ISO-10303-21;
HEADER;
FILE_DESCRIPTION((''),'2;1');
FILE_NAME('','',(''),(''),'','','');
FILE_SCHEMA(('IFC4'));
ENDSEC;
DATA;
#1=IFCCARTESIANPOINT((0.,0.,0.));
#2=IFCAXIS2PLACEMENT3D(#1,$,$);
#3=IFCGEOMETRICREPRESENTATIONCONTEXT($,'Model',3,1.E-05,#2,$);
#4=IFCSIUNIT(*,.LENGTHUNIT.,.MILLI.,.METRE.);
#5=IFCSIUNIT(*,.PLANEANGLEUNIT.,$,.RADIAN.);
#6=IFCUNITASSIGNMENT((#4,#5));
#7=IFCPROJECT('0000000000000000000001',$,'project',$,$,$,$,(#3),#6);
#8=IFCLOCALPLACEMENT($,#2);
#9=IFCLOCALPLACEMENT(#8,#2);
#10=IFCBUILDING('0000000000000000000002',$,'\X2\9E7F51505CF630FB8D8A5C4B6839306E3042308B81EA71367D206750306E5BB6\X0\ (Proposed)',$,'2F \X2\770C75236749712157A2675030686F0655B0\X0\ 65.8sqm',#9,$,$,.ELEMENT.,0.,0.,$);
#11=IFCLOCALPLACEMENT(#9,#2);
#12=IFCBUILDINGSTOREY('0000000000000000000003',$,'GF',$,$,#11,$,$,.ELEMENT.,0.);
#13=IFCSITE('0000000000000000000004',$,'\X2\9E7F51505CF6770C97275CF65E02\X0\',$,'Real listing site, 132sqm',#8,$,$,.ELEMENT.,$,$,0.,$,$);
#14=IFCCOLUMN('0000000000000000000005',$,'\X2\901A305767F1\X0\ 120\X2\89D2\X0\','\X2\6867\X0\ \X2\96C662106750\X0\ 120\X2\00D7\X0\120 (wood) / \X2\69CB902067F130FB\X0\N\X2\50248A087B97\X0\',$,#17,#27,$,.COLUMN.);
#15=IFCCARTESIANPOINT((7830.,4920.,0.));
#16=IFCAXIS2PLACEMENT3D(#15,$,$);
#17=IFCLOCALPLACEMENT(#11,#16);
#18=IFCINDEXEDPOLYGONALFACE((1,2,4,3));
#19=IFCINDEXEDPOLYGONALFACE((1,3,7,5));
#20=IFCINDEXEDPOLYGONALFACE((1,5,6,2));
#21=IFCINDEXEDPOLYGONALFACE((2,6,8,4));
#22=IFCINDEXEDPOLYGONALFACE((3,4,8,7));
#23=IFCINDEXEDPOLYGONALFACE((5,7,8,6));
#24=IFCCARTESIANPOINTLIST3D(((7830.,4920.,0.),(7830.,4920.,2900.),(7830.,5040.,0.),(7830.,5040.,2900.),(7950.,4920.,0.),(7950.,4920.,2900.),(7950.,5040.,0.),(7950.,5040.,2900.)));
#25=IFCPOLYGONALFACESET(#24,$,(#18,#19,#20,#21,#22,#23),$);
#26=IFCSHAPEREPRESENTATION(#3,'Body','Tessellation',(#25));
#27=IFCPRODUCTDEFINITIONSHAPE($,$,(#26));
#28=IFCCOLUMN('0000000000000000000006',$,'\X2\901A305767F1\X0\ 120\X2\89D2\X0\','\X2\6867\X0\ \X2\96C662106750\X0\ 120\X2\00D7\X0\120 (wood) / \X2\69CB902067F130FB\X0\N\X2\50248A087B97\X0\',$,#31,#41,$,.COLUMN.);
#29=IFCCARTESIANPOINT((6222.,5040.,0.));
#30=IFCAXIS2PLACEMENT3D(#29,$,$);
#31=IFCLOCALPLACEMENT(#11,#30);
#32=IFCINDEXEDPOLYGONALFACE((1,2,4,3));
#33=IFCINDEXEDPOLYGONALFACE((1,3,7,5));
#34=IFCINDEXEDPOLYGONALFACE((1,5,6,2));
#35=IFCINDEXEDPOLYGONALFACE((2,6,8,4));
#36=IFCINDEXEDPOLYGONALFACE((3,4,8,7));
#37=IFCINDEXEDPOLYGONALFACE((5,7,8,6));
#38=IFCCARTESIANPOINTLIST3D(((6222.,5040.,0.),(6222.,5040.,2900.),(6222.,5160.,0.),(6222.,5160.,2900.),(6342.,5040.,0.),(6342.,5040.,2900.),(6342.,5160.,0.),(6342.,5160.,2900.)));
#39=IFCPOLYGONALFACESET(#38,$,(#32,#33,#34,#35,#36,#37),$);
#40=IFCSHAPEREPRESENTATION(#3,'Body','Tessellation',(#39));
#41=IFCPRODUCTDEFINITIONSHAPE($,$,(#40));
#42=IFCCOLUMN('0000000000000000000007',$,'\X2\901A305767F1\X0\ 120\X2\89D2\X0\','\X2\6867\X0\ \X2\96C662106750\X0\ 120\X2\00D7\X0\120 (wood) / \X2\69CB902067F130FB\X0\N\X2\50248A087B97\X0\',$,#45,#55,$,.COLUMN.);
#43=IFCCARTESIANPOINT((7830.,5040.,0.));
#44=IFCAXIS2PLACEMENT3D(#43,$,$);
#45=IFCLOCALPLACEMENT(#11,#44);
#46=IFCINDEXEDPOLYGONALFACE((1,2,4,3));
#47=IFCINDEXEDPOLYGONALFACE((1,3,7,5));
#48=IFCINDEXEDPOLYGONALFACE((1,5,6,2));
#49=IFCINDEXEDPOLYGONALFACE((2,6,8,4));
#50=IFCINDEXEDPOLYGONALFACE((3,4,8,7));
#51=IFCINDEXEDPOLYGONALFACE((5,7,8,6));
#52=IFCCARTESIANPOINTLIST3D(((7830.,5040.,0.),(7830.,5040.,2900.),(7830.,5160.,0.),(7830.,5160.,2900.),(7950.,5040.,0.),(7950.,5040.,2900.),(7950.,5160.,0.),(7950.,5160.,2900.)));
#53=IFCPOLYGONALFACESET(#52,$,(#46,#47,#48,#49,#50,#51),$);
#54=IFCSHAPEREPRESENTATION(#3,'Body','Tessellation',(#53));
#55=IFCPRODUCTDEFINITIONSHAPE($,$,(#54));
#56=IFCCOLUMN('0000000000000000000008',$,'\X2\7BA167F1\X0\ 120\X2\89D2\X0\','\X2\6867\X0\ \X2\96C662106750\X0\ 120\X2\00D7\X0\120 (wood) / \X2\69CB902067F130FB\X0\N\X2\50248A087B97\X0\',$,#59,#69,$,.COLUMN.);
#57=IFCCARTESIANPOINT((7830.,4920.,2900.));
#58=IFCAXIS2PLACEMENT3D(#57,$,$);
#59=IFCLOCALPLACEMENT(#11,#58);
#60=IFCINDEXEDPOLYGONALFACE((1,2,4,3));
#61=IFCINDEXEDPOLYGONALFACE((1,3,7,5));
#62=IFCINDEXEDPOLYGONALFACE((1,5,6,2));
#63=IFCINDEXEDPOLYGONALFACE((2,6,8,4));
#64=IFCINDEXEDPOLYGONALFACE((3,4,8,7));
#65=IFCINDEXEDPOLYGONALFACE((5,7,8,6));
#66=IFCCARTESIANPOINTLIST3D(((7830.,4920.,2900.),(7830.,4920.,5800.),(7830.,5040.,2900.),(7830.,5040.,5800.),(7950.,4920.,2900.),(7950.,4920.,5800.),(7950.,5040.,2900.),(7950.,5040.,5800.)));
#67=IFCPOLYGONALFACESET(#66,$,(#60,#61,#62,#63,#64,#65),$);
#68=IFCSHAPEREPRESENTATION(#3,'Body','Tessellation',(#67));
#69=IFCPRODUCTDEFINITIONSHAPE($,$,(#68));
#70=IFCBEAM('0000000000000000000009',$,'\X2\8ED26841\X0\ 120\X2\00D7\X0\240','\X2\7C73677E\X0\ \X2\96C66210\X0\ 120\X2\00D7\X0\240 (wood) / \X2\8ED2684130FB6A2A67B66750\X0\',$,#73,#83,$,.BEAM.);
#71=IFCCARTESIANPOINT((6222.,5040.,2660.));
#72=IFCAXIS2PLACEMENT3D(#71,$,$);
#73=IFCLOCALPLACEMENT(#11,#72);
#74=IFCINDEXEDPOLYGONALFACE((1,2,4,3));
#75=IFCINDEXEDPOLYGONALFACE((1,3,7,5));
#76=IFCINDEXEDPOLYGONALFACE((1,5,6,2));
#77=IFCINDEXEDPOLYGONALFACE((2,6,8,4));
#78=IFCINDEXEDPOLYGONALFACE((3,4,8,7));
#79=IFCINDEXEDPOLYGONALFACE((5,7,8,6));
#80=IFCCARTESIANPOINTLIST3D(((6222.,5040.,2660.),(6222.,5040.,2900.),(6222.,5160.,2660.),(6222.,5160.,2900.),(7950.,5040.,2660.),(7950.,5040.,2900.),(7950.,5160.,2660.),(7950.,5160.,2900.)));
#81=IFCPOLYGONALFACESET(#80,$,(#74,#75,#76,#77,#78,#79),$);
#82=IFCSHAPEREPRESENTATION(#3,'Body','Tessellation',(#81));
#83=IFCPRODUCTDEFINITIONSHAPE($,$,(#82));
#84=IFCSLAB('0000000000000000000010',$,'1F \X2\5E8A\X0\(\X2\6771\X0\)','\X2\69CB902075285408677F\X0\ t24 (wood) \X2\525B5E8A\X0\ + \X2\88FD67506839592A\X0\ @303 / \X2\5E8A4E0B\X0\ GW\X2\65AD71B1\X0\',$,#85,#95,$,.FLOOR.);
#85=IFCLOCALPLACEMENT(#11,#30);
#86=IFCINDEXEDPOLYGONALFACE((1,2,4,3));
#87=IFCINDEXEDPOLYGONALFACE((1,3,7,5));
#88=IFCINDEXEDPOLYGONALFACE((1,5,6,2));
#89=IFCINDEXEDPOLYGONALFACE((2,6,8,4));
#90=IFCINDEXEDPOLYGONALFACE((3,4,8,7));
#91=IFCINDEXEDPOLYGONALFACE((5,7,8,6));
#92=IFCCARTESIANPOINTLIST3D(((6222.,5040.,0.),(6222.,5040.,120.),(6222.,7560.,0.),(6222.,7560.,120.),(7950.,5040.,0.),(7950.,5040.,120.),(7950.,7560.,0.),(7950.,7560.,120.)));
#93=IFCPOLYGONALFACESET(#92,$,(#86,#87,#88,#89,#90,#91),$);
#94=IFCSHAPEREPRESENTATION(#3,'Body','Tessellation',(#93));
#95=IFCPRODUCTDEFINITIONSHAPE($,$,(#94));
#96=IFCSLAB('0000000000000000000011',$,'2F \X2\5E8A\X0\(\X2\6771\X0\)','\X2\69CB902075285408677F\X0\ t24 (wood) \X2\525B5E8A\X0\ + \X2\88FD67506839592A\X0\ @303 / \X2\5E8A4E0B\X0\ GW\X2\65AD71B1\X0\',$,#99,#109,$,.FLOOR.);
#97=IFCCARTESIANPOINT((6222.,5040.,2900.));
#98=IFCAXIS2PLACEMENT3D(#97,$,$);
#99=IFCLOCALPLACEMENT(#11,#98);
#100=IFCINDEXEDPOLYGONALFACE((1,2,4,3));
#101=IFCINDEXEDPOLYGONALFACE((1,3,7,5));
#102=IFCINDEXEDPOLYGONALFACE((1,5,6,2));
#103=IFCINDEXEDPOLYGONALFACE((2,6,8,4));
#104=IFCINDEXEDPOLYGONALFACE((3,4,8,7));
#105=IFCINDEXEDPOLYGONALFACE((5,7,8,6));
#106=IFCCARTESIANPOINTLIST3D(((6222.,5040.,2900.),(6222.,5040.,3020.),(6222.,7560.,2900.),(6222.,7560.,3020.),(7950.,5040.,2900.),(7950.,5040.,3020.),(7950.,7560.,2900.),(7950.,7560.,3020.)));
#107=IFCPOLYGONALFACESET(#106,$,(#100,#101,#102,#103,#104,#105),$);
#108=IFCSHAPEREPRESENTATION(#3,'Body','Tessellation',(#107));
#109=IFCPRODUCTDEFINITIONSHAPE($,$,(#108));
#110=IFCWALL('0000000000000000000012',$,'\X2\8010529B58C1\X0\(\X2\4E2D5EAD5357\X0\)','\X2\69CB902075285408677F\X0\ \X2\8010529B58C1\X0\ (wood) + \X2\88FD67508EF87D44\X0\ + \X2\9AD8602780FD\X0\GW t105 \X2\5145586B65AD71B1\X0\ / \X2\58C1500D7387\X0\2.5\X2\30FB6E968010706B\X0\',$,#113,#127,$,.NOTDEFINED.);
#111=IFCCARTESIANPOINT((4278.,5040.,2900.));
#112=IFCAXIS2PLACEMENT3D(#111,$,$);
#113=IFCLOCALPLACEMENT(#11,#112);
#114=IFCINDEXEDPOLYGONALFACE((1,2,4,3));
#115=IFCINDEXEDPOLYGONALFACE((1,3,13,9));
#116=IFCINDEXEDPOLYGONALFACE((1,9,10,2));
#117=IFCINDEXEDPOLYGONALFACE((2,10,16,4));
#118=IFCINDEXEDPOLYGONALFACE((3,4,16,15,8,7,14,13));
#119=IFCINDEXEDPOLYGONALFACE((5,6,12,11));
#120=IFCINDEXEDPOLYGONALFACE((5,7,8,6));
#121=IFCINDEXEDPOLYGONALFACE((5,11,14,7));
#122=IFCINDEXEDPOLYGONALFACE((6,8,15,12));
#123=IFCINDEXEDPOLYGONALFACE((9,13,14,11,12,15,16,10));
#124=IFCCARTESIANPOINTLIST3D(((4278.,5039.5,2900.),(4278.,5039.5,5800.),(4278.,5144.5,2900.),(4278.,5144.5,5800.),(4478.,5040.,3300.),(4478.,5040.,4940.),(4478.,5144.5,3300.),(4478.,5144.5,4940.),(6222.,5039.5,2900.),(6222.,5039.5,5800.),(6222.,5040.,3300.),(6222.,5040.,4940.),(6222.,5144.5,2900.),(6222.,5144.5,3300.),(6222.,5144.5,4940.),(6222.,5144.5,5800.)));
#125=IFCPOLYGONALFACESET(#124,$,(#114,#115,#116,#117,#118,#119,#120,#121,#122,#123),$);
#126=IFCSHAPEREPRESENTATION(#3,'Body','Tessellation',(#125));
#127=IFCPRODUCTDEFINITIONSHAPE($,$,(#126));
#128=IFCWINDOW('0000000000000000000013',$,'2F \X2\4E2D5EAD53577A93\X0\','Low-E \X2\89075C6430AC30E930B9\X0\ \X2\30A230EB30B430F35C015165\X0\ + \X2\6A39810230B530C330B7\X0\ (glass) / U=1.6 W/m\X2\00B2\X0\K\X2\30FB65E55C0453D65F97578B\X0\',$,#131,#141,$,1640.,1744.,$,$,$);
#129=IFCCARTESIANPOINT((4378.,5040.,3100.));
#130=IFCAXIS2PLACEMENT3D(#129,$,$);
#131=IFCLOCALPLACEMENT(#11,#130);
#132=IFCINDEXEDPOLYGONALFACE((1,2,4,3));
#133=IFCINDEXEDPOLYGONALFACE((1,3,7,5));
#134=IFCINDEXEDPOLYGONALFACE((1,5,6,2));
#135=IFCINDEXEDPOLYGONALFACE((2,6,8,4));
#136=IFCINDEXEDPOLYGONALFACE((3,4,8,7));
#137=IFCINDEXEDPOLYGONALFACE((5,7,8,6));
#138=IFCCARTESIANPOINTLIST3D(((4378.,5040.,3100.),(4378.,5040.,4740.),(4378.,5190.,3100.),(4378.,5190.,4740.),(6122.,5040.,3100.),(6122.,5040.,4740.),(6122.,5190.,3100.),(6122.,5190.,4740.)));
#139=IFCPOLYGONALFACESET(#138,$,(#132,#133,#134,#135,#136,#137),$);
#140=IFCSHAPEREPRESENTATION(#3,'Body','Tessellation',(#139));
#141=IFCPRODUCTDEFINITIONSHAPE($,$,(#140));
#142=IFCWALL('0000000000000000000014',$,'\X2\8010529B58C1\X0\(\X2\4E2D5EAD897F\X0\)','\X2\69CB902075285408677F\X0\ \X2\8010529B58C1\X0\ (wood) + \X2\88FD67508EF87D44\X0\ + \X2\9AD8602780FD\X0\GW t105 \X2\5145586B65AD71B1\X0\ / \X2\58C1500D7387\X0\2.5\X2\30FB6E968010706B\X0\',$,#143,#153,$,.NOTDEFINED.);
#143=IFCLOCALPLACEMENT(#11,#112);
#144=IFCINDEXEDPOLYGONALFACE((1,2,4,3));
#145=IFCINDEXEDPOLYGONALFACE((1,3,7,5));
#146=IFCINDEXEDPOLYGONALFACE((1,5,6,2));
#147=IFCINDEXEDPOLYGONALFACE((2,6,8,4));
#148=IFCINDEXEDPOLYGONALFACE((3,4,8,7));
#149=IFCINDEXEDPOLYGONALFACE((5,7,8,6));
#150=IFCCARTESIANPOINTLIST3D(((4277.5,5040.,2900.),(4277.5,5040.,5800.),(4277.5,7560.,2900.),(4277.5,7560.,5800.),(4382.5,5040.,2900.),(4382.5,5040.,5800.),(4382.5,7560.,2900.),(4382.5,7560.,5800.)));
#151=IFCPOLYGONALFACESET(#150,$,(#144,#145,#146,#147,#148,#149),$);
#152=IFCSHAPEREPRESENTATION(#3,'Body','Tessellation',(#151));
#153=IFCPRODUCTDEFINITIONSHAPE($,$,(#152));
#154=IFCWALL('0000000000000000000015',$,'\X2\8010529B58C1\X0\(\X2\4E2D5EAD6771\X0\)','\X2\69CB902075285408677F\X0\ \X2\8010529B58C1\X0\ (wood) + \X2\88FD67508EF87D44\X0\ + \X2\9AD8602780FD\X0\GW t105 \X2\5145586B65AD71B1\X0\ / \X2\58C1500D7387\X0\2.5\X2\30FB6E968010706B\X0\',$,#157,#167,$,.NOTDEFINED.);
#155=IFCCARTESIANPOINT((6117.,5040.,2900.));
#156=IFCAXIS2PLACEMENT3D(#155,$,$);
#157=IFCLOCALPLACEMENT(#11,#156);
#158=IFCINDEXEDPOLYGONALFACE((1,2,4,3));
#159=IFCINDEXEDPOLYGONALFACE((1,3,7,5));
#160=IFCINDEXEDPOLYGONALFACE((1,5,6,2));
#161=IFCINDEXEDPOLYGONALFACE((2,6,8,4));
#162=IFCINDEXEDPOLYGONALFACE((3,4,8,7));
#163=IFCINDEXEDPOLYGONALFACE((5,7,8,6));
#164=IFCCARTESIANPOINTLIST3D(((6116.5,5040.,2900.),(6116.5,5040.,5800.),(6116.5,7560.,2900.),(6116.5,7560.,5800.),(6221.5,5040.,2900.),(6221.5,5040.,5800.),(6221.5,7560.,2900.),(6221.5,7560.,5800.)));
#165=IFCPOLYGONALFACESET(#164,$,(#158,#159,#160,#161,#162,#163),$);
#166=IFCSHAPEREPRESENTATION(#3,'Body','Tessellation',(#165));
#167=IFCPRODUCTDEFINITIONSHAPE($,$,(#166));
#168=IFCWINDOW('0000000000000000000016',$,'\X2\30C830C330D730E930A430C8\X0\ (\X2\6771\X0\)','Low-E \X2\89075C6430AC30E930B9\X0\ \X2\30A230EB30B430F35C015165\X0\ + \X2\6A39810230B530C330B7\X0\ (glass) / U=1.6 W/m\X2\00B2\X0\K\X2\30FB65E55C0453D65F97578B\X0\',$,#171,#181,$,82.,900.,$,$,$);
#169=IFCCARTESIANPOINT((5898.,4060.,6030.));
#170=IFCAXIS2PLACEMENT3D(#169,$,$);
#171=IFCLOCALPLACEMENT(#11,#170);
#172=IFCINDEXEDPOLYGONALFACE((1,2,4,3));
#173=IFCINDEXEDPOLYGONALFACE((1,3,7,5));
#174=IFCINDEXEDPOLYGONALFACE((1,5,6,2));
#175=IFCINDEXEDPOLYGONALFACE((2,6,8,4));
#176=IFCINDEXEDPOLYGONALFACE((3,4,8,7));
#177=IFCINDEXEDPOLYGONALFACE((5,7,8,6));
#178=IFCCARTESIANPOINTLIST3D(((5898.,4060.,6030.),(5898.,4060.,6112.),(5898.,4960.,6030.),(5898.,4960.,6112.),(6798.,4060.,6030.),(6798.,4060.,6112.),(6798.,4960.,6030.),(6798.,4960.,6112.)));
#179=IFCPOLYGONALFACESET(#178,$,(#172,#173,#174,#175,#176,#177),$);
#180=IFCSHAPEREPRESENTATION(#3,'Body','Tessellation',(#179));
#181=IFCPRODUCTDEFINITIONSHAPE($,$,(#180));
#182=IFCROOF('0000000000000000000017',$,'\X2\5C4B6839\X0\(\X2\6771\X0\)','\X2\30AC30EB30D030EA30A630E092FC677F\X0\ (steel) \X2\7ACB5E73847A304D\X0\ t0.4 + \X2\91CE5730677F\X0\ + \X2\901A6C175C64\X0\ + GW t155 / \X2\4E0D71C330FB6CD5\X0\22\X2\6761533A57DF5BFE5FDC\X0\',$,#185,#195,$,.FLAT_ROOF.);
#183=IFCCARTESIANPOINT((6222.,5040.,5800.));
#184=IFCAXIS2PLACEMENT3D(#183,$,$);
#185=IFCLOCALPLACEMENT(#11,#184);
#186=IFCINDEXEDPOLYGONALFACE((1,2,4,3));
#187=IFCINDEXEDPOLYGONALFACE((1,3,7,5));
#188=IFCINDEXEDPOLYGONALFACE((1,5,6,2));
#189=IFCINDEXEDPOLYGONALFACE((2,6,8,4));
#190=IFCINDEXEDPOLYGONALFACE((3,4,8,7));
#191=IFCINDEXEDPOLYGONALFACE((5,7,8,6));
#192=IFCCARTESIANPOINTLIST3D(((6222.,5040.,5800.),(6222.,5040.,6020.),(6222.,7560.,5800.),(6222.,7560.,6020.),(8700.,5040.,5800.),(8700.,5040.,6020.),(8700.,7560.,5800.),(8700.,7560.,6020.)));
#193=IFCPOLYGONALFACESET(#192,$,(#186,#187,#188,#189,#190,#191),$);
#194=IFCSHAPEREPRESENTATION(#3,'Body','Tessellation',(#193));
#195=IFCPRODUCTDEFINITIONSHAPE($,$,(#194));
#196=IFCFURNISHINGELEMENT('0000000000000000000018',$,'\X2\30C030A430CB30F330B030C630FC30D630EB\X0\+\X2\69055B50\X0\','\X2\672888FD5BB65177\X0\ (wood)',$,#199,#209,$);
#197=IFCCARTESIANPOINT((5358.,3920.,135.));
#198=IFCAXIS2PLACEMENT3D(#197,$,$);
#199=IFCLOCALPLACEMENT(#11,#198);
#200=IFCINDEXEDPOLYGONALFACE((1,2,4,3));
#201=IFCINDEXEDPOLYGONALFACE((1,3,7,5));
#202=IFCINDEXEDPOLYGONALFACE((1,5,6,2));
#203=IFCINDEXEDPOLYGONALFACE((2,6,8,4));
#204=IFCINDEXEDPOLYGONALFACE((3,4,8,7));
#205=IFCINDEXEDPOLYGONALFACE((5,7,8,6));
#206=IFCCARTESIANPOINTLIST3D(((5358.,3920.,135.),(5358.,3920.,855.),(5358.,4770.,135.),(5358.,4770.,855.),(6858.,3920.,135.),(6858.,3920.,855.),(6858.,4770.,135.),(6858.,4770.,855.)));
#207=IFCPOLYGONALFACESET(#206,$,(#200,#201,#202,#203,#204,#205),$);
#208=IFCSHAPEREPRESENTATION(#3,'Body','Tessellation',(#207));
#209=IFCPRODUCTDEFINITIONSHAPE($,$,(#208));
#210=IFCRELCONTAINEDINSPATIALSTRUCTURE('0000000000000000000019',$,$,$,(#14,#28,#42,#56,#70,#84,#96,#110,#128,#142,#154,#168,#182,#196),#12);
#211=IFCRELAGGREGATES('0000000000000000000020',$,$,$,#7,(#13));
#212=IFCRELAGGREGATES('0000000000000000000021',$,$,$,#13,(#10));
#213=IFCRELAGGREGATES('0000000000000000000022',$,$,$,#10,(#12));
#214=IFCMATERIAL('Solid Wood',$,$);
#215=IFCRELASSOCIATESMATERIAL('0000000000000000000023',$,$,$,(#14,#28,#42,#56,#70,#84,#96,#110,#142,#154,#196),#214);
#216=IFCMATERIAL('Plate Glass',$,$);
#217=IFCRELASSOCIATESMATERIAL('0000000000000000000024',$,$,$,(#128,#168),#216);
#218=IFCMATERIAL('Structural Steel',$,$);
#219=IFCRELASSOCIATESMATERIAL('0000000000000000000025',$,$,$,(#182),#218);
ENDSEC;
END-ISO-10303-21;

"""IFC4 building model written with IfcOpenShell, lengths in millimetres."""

from ifc_helpers import new_model, si_unit, frame, frame_2d, origin, place, context, project, spatial, rectangle, extrude, material, element, fill, save


model = new_model("IFC4")

# Units and contexts
model_context = context("Model", 3, precision=1e-05, world=origin())
ifc_project = project(units=[si_unit("LENGTHUNIT", "METRE", prefix="MILLI"), si_unit("PLANEANGLEUNIT", "RADIAN")], contexts=[model_context])

# Site, building, storey
site_placement = place(None, origin())
site = spatial("IfcSite", under=ifc_project, at=site_placement, Name="鹿児島県霧島市", ObjectType="Real listing site, 132sqm", CompositionType="ELEMENT", RefElevation=0.0)
building_placement = place(site_placement, origin())
building = spatial("IfcBuilding", under=site, at=building_placement, Name="鹿児島・越屋根のある自然素材の家 (Proposed)", ObjectType="2F 県産杉無垢材と漆喰 65.8sqm", CompositionType="ELEMENT", ElevationOfRefHeight=0.0, ElevationOfTerrain=0.0)
storey_placement = place(building_placement, origin())
storey = spatial("IfcBuildingStorey", under=building, at=storey_placement, Name="GF", CompositionType="ELEMENT", Elevation=0.0)

# Columns
ifc_material_1 = material(Name="Solid Wood")
column_1_placement = place(storey_placement, frame((7830.0, 4920.0, 0.0)))
element("IfcColumn", 1, at=column_1_placement, inside=storey, material=ifc_material_1, Name="通し柱 120角", Description="桧 集成材 120×120 (wood) / 構造柱・N値計算", PredefinedType="COLUMN", context=model_context, shape_type="SweptSolid", body=[
    extrude(rectangle(XDim=120.0, YDim=120.0, at=frame_2d((60.0, 60.0))), frame((7830.0, 4920.0, 0.0)), (0.0, 0.0, 1.0), 2900.0),
])
column_2_placement = place(storey_placement, frame((6222.0, 5040.0, 0.0)))
element("IfcColumn", 2, at=column_2_placement, inside=storey, material=ifc_material_1, Name="通し柱 120角", Description="桧 集成材 120×120 (wood) / 構造柱・N値計算", PredefinedType="COLUMN", context=model_context, shape_type="SweptSolid", body=[
    extrude(rectangle(XDim=120.0, YDim=120.0, at=frame_2d((60.0, 60.0))), frame((6222.0, 5040.0, 0.0)), (0.0, 0.0, 1.0), 2900.0),
])
column_3_placement = place(storey_placement, frame((7830.0, 5040.0, 0.0)))
element("IfcColumn", 3, at=column_3_placement, inside=storey, material=ifc_material_1, Name="通し柱 120角", Description="桧 集成材 120×120 (wood) / 構造柱・N値計算", PredefinedType="COLUMN", context=model_context, shape_type="SweptSolid", body=[
    extrude(rectangle(XDim=120.0, YDim=120.0, at=frame_2d((60.0, 60.0))), frame((7830.0, 5040.0, 0.0)), (0.0, 0.0, 1.0), 2900.0),
])
column_4_placement = place(storey_placement, frame((7830.0, 4920.0, 2900.0)))
element("IfcColumn", 4, at=column_4_placement, inside=storey, material=ifc_material_1, Name="管柱 120角", Description="桧 集成材 120×120 (wood) / 構造柱・N値計算", PredefinedType="COLUMN", context=model_context, shape_type="SweptSolid", body=[
    extrude(rectangle(XDim=120.0, YDim=120.0, at=frame_2d((60.0, 60.0))), frame((7830.0, 4920.0, 2900.0)), (0.0, 0.0, 1.0), 2900.0),
])

# Beam
beam_1_placement = place(storey_placement, frame((6222.0, 5040.0, 2660.0)))
element("IfcBeam", 5, at=beam_1_placement, inside=storey, material=ifc_material_1, Name="軒桁 120×240", Description="米松 集成 120×240 (wood) / 軒桁・横架材", PredefinedType="BEAM", context=model_context, shape_type="SweptSolid", body=[
    extrude(rectangle(XDim=1728.0, YDim=120.0, at=frame_2d((864.0, 60.0))), frame((6222.0, 5040.0, 2660.0)), (0.0, 0.0, 1.0), 240.0),
])

# Slabs
slab_1_placement = place(storey_placement, frame((6222.0, 5040.0, 0.0)))
element("IfcSlab", 6, at=slab_1_placement, inside=storey, material=ifc_material_1, Name="1F 床(東)", Description="構造用合板 t24 (wood) 剛床 + 製材根太 @303 / 床下 GW断熱", PredefinedType="FLOOR", context=model_context, shape_type="SweptSolid", body=[
    extrude(rectangle(XDim=1728.0, YDim=2520.0, at=frame_2d((864.0, 1260.0))), frame((6222.0, 5040.0, 0.0)), (0.0, 0.0, 1.0), 120.0),
])
slab_2_placement = place(storey_placement, frame((6222.0, 5040.0, 2900.0)))
element("IfcSlab", 7, at=slab_2_placement, inside=storey, material=ifc_material_1, Name="2F 床(東)", Description="構造用合板 t24 (wood) 剛床 + 製材根太 @303 / 床下 GW断熱", PredefinedType="FLOOR", context=model_context, shape_type="SweptSolid", body=[
    extrude(rectangle(XDim=1728.0, YDim=2520.0, at=frame_2d((864.0, 1260.0))), frame((6222.0, 5040.0, 2900.0)), (0.0, 0.0, 1.0), 120.0),
])

# Wall, opening, window
wall_1_placement = place(storey_placement, frame((4278.0, 5040.0, 2900.0)))
wall_1 = element("IfcWall", 8, at=wall_1_placement, inside=storey, material=ifc_material_1, Name="耐力壁(中庭南)", Description="構造用合板 耐力壁 (wood) + 製材軸組 + 高性能GW t105 充填断熱 / 壁倍率2.5・準耐火", PredefinedType="NOTDEFINED", context=model_context, shape_type="SweptSolid", body=[
    extrude(rectangle(XDim=1944.0, YDim=105.0, at=frame_2d((972.0, 52.0))), frame((4278.0, 5040.0, 2900.0)), (0.0, 0.0, 1.0), 2900.0),
])
opening_placement = place(storey_placement, frame((4378.0, 5040.0, 3100.0)))
opening = element("IfcOpeningElement", 9, at=opening_placement, cuts=wall_1, PredefinedType="NOTDEFINED", context=model_context, shape_type="SweptSolid", body=[
    extrude(rectangle(XDim=1744.0, YDim=150.0, at=frame_2d((872.0, 75.0))), frame((4378.0, 5040.0, 3100.0)), (0.0, 0.0, 1.0), 1640.0),
])
ifc_material_2 = material(Name="Plate Glass")
window_1_placement = place(storey_placement, frame((4378.0, 5040.0, 3100.0)))
window_1 = element("IfcWindow", 10, at=window_1_placement, inside=storey, material=ifc_material_2, Name="2F 中庭南窓", Description="Low-E 複層ガラス アルゴン封入 + 樹脂サッシ (glass) / U=1.6 W/m²K・日射取得型", OverallHeight=1640.0, OverallWidth=1744.0, context=model_context, shape_type="SweptSolid", body=[
    extrude(rectangle(XDim=1744.0, YDim=150.0, at=frame_2d((872.0, 75.0))), frame((4378.0, 5040.0, 3100.0)), (0.0, 0.0, 1.0), 1640.0),
])
fill(opening, window_1)

# Walls
wall_2_placement = place(storey_placement, frame((4278.0, 5040.0, 2900.0)))
element("IfcWall", 11, at=wall_2_placement, inside=storey, material=ifc_material_1, Name="耐力壁(中庭西)", Description="構造用合板 耐力壁 (wood) + 製材軸組 + 高性能GW t105 充填断熱 / 壁倍率2.5・準耐火", PredefinedType="NOTDEFINED", context=model_context, shape_type="SweptSolid", body=[
    extrude(rectangle(XDim=105.0, YDim=2520.0, at=frame_2d((52.0, 1260.0))), frame((4278.0, 5040.0, 2900.0)), (0.0, 0.0, 1.0), 2900.0),
])
wall_3_placement = place(storey_placement, frame((6117.0, 5040.0, 2900.0)))
element("IfcWall", 12, at=wall_3_placement, inside=storey, material=ifc_material_1, Name="耐力壁(中庭東)", Description="構造用合板 耐力壁 (wood) + 製材軸組 + 高性能GW t105 充填断熱 / 壁倍率2.5・準耐火", PredefinedType="NOTDEFINED", context=model_context, shape_type="SweptSolid", body=[
    extrude(rectangle(XDim=105.0, YDim=2520.0, at=frame_2d((52.0, 1260.0))), frame((6117.0, 5040.0, 2900.0)), (0.0, 0.0, 1.0), 2900.0),
])

# Window
window_2_placement = place(storey_placement, frame((5898.0, 4060.0, 6030.0)))
element("IfcWindow", 13, at=window_2_placement, inside=storey, material=ifc_material_2, Name="トップライト (東)", Description="Low-E 複層ガラス アルゴン封入 + 樹脂サッシ (glass) / U=1.6 W/m²K・日射取得型", OverallHeight=82.0, OverallWidth=900.0, context=model_context, shape_type="SweptSolid", body=[
    extrude(rectangle(XDim=900.0, YDim=900.0, at=frame_2d((450.0, 450.0))), frame((5898.0, 4060.0, 6030.0)), (0.0, 0.0, 1.0), 82.0),
])

# Roof
ifc_material_3 = material(Name="Structural Steel")
for number, where, name in (
    (14, (6222.0, 5040.0, 5800.0), "屋根(東)"),
):
    element("IfcRoof", number, at=place(storey_placement, frame(where)), inside=storey, material=ifc_material_3, Name=name, Description="ガルバリウム鋼板 (steel) 立平葺き t0.4 + 野地板 + 通気層 + GW t155 / 不燃・法22条区域対応", PredefinedType="FLAT_ROOF", context=model_context, shape_type="SweptSolid", body=[
        extrude(rectangle(XDim=2478.0, YDim=2520.0, at=frame_2d((1239.0, 1260.0))), frame((6222.0, 5040.0, 5800.0)), (0.0, 0.0, 1.0), 220.0),
    ])

# Furnishing element
furnishing_1_placement = place(storey_placement, frame((5358.0, 3920.0, 135.0)))
element("IfcFurnishingElement", 15, at=furnishing_1_placement, inside=storey, material=ifc_material_1, Name="ダイニングテーブル+椅子", Description="木製家具 (wood)", context=model_context, shape_type="SweptSolid", body=[
    extrude(rectangle(XDim=1500.0, YDim=850.0, at=frame_2d((750.0, 425.0))), frame((5358.0, 3920.0, 135.0)), (0.0, 0.0, 1.0), 720.0),
])

save(model, "model.ifc")
